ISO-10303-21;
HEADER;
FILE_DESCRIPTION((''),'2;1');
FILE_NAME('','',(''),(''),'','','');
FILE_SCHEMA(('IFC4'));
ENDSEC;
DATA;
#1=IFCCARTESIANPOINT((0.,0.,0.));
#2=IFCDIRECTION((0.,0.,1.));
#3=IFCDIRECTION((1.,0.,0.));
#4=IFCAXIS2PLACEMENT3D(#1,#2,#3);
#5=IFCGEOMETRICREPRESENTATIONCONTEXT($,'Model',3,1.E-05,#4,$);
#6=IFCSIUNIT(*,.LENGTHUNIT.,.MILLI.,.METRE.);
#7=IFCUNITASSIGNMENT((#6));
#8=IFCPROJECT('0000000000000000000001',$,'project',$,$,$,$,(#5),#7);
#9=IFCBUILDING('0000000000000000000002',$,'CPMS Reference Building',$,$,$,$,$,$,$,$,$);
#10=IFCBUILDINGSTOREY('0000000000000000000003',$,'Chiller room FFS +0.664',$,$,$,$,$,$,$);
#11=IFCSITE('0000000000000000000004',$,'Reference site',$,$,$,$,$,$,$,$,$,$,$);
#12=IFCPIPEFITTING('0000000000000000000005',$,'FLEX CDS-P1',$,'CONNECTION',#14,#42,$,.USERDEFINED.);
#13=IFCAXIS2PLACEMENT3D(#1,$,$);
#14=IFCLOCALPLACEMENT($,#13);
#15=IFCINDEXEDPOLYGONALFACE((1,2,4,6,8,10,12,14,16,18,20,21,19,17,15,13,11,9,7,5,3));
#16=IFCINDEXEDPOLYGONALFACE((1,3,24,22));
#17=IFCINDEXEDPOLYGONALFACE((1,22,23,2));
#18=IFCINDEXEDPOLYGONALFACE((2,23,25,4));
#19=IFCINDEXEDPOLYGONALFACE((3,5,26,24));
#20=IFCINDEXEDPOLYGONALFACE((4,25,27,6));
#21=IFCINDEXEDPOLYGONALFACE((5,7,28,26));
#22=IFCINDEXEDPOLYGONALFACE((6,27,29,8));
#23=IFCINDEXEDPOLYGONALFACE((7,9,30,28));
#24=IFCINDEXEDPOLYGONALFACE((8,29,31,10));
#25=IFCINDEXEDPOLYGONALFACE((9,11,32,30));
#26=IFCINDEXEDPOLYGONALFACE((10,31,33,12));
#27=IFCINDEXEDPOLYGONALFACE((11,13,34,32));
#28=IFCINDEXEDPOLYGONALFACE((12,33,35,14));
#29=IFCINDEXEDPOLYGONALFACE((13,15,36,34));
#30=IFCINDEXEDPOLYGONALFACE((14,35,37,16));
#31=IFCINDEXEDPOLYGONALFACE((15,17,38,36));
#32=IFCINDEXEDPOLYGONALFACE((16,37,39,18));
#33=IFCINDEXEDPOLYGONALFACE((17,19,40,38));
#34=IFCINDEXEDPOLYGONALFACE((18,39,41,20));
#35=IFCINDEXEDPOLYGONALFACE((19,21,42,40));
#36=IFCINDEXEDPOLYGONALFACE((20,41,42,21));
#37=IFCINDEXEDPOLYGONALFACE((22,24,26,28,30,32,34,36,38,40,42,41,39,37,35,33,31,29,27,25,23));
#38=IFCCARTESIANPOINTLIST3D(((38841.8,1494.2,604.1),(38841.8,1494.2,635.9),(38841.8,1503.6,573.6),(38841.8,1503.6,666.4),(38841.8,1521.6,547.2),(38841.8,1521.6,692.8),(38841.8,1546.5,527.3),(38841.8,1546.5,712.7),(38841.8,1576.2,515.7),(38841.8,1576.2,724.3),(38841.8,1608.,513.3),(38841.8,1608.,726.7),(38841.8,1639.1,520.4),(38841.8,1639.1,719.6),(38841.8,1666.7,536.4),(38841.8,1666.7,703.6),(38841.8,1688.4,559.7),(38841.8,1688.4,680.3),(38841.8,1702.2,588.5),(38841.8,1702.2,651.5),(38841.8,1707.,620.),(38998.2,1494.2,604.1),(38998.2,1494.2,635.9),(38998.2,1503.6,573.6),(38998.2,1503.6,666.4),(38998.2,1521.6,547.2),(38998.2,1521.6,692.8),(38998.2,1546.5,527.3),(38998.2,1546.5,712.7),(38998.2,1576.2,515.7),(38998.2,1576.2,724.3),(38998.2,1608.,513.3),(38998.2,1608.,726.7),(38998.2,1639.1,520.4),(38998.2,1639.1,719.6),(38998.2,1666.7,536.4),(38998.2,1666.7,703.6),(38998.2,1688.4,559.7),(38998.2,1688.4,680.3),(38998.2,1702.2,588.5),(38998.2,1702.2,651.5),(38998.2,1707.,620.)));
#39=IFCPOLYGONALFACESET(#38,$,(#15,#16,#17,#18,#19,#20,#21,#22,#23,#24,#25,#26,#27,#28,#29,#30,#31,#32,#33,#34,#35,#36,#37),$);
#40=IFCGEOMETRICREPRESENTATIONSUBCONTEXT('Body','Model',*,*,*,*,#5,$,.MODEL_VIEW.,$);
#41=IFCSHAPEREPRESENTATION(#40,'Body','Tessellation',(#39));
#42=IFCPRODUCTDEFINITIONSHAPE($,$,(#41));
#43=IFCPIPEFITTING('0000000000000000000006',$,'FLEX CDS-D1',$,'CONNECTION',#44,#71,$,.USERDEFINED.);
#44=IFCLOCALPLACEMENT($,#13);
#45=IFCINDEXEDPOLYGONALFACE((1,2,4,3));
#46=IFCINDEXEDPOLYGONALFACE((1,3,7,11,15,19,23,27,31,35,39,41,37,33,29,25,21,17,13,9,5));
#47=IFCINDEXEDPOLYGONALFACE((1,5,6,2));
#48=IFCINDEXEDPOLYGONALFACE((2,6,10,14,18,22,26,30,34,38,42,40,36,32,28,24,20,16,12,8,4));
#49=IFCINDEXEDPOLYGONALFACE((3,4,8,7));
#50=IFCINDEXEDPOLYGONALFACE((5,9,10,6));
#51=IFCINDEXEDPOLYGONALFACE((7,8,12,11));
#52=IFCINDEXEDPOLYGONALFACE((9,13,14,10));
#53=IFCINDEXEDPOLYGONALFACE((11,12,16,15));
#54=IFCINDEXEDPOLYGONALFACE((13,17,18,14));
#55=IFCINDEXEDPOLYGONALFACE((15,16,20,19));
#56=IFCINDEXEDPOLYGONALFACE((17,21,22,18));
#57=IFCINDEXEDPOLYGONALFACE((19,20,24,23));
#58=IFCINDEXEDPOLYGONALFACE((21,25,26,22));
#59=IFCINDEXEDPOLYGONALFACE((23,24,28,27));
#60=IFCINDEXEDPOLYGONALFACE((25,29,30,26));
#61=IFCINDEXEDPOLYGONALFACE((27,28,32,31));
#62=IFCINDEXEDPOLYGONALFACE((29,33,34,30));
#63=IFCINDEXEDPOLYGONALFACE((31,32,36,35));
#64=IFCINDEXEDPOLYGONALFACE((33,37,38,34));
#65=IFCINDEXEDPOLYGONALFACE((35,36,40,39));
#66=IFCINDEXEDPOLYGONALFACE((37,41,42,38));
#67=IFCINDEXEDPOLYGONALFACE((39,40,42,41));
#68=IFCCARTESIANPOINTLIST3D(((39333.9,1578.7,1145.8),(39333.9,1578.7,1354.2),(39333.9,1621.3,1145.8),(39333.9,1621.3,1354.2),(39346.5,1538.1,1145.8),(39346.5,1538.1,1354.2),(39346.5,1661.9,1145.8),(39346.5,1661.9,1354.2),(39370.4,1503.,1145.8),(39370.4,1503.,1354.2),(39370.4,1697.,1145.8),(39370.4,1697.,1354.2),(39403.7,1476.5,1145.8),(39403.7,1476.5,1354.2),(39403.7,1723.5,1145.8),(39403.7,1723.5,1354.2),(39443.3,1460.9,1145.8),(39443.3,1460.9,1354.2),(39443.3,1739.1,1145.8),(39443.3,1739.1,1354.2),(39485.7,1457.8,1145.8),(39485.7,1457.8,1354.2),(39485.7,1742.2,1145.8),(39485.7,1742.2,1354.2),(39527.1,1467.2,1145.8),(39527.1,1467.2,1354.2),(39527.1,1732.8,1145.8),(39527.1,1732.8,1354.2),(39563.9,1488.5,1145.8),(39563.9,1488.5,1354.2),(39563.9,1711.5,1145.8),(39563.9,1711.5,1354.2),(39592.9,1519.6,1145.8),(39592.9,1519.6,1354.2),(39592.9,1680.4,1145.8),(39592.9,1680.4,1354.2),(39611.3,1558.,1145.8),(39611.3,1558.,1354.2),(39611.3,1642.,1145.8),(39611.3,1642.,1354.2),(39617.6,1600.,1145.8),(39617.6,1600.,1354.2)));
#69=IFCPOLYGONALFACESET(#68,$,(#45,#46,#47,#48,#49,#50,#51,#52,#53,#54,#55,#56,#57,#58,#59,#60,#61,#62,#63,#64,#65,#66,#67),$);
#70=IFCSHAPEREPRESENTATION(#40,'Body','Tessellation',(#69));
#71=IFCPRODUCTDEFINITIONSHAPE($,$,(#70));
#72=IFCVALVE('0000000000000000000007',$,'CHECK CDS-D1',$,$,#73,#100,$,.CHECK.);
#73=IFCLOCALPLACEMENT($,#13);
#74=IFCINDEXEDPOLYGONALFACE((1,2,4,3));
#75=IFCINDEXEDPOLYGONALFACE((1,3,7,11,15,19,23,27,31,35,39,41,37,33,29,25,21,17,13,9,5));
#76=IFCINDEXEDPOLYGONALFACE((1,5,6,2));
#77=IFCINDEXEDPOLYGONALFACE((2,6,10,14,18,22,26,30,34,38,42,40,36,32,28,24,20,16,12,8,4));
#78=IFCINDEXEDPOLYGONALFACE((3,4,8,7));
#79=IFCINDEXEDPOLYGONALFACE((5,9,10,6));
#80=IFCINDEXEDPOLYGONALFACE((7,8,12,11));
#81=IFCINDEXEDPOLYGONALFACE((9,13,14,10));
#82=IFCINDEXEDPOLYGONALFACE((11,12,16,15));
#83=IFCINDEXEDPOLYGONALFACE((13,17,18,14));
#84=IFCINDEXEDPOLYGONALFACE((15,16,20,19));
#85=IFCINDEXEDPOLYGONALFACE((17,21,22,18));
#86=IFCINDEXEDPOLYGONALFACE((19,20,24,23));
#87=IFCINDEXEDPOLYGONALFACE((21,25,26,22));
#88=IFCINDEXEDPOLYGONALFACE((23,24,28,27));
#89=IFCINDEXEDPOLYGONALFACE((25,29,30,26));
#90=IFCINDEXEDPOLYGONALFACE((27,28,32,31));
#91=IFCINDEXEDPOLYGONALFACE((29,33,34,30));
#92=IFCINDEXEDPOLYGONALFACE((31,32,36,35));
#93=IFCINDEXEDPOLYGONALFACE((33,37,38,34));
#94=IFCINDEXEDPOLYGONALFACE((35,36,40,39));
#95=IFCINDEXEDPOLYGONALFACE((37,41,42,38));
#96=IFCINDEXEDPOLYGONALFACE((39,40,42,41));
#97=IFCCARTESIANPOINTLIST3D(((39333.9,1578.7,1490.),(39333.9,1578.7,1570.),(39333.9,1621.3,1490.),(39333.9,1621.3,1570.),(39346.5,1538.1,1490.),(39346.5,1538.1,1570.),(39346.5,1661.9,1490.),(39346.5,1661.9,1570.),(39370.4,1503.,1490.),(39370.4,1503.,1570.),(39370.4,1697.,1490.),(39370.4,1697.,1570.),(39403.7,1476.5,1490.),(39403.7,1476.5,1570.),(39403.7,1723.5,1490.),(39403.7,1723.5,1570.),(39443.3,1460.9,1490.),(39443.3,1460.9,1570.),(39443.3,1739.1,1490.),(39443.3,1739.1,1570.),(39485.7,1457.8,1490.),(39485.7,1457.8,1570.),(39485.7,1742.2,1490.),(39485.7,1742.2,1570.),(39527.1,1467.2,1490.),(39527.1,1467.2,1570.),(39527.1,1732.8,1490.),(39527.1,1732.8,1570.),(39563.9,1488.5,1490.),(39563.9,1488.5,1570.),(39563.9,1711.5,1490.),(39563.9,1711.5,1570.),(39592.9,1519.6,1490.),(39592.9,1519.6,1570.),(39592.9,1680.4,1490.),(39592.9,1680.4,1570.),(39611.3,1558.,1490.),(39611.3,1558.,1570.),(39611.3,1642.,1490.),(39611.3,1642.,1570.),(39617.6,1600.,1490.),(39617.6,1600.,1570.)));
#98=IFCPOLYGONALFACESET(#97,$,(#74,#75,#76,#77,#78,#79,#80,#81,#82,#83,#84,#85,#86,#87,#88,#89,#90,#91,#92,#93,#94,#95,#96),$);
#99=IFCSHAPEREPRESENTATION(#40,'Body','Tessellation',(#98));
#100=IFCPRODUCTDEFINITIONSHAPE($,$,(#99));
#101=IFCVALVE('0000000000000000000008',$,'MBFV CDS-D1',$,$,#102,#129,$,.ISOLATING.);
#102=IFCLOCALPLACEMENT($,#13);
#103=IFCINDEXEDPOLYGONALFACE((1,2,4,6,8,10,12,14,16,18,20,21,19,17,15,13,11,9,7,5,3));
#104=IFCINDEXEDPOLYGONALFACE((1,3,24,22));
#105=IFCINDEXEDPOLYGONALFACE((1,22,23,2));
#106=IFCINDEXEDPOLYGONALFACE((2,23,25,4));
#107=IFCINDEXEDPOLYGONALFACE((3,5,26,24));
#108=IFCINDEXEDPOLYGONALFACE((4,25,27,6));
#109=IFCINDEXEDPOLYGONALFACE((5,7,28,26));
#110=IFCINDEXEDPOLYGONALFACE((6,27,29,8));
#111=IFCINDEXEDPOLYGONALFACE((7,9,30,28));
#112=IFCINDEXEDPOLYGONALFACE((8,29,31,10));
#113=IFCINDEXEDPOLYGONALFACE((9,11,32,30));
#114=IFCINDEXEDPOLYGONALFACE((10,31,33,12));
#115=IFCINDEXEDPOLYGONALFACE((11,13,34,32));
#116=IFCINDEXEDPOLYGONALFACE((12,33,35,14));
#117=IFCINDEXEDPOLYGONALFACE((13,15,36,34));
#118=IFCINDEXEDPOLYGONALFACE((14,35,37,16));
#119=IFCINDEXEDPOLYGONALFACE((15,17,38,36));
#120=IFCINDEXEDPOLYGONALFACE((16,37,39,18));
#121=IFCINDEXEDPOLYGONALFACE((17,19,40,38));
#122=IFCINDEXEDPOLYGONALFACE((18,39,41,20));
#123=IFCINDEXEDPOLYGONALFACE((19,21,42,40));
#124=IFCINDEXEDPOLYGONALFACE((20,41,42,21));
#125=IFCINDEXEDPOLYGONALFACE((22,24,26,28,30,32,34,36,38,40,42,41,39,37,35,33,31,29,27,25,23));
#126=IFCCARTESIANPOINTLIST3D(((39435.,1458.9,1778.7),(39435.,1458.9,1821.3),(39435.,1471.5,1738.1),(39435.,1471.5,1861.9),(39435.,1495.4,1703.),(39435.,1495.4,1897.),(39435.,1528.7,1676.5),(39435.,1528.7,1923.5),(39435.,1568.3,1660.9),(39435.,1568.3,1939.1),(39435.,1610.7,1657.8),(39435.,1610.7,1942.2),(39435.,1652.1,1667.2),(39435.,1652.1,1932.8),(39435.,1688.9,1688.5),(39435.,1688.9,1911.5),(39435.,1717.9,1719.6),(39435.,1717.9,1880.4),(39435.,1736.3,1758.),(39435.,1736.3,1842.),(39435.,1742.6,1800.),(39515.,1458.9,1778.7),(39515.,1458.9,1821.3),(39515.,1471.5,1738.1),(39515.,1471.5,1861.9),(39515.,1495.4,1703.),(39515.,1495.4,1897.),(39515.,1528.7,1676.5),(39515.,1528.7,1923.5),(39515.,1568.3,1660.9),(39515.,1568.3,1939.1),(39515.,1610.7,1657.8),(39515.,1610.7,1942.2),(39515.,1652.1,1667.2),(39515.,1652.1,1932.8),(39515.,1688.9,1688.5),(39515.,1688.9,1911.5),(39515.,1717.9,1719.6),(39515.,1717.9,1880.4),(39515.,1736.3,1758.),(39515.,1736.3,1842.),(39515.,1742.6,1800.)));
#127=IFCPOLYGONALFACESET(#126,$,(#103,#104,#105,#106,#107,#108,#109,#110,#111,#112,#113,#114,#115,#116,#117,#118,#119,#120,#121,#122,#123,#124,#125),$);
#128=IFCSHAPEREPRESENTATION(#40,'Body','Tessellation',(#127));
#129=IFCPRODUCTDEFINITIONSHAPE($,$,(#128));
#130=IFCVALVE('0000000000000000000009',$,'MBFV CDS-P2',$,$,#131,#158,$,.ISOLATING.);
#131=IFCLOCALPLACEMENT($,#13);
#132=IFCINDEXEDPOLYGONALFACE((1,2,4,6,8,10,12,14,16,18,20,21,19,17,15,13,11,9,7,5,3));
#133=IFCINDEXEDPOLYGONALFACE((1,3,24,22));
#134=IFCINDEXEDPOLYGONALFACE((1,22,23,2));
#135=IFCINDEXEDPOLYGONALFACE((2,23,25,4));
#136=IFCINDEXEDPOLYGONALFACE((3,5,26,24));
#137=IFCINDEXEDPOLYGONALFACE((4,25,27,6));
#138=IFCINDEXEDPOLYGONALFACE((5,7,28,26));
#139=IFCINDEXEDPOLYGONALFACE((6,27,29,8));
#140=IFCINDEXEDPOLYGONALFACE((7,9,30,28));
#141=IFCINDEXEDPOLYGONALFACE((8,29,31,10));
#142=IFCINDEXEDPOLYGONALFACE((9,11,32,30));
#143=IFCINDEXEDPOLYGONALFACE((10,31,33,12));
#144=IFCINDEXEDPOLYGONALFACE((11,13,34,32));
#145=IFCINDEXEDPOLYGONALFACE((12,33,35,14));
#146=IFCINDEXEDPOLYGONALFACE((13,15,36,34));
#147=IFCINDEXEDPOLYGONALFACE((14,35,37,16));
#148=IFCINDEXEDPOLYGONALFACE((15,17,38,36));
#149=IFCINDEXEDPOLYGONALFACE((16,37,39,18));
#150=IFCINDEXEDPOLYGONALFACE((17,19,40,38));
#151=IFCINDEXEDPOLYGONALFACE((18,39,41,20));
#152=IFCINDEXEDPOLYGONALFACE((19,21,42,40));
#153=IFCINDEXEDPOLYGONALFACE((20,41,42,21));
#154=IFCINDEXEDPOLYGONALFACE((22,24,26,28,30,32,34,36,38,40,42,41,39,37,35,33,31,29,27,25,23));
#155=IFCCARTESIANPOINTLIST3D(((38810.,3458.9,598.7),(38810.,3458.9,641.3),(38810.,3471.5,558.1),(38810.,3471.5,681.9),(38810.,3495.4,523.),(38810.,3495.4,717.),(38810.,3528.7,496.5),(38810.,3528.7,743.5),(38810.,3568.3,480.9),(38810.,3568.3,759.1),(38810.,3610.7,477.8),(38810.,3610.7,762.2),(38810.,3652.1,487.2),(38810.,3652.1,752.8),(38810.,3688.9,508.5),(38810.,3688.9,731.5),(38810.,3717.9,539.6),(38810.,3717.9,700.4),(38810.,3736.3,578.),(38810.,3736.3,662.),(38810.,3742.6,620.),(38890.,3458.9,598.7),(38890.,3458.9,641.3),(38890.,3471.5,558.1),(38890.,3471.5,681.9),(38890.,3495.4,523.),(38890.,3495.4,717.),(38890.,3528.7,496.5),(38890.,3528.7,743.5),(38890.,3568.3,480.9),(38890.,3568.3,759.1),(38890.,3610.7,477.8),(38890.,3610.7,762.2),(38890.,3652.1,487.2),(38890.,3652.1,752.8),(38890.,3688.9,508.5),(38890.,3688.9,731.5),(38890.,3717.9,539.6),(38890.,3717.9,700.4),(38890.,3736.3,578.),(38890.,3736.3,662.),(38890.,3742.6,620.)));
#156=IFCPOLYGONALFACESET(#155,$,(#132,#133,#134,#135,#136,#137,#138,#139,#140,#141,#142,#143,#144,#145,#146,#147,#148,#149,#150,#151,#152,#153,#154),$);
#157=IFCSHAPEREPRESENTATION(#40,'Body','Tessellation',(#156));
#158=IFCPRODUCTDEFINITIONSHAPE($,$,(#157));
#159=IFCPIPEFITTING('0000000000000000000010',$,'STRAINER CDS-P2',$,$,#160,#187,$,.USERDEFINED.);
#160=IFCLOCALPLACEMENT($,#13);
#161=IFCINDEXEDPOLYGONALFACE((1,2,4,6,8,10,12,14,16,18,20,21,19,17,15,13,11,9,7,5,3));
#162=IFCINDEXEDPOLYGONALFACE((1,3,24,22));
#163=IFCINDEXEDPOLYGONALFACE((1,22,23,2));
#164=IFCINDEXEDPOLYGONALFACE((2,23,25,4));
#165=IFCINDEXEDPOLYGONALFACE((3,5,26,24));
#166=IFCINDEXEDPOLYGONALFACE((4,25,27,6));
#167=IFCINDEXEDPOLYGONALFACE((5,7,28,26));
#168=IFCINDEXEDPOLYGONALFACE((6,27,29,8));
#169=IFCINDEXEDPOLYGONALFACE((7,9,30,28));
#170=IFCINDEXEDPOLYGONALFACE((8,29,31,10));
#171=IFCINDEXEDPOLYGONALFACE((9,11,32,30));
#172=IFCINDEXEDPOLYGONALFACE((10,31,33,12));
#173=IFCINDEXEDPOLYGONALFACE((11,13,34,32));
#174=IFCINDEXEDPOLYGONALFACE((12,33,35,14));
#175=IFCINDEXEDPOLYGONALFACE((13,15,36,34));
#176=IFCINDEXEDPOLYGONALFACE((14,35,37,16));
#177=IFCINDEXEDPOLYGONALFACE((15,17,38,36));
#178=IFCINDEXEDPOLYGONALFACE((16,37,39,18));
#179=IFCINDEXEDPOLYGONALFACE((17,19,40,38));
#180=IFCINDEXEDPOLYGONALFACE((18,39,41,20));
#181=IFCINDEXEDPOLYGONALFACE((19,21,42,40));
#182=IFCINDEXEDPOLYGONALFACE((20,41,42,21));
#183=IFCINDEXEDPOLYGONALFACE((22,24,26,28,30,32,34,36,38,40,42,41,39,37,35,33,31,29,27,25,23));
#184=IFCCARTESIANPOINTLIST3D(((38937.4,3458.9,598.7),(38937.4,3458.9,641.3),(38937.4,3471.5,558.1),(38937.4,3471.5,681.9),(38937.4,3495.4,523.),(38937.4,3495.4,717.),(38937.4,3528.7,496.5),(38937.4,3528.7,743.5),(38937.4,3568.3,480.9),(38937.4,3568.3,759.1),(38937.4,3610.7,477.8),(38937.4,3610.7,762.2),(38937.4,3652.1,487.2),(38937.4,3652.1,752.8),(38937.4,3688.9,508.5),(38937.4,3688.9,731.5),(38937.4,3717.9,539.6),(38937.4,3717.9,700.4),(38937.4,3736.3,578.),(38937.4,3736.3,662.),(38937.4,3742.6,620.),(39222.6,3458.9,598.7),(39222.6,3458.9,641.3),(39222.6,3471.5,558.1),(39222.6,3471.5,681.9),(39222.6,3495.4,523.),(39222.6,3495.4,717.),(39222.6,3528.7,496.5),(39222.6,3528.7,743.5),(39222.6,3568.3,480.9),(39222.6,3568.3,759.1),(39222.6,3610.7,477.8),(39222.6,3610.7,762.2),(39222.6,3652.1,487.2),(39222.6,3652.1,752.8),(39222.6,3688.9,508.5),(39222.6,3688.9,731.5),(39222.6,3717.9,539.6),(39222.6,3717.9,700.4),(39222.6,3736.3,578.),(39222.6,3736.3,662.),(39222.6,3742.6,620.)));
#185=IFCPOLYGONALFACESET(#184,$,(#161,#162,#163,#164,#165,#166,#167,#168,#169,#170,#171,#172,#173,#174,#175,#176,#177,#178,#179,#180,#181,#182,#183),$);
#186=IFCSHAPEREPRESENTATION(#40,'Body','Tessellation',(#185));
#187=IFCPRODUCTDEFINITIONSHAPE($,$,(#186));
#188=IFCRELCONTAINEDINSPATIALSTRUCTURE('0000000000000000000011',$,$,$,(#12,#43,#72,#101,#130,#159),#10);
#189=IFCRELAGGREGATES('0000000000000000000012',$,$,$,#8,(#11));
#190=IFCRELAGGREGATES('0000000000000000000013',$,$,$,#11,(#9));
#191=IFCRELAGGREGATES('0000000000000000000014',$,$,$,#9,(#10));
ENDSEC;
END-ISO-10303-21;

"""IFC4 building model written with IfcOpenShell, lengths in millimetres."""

from ifc_helpers import new_model, si_unit, frame, origin_with_axes, origin_2d, place, context, subcontext, project, spatial, circle_curve, outline, extrude, element, save


model = new_model("IFC4")

# Units and contexts
model_context = context("Model", 3, precision=1e-05, world=origin_with_axes())
body_context = subcontext(model_context, "Body", "Model", "MODEL_VIEW")
ifc_project = project(units=[si_unit("LENGTHUNIT", "METRE", prefix="MILLI")], contexts=[model_context])

# Site, building, storey
site = spatial("IfcSite", under=ifc_project, Name="Reference site")
building = spatial("IfcBuilding", under=site, Name="CPMS Reference Building")
storey = spatial("IfcBuildingStorey", under=building, Name="Chiller room FFS +0.664")

# Pipe fittings
pipe_fitting_1_placement = place(None, origin_with_axes())
element("IfcPipeFitting", 1, at=pipe_fitting_1_placement, inside=storey, Name="FLEX CDS-P1", ObjectType="CONNECTION", PredefinedType="USERDEFINED", context=body_context, shape_type="SweptSolid", body=[
    extrude(outline(circle_curve(origin_2d(), 107.0)), frame((38841.8, 1600.0, 620.0), z_axis=(1.0, 0.0, 0.0), x_axis=(0.0, 1.0, 0.0)), (0.0, 0.0, 1.0), 156.4),
])
pipe_fitting_2_placement = place(None, origin_with_axes())
element("IfcPipeFitting", 2, at=pipe_fitting_2_placement, inside=storey, Name="FLEX CDS-D1", ObjectType="CONNECTION", PredefinedType="USERDEFINED", context=body_context, shape_type="SweptSolid", body=[
    extrude(outline(circle_curve(origin_2d(), 142.6)), frame((39475.0, 1600.0, 1145.8), z_axis=(0.0, 0.0, 1.0), x_axis=(1.0, 0.0, 0.0)), (0.0, 0.0, 1.0), 208.5),
])

# Valves
valve_1_placement = place(None, origin_with_axes())
element("IfcValve", 3, at=valve_1_placement, inside=storey, Name="CHECK CDS-D1", PredefinedType="CHECK", context=body_context, shape_type="SweptSolid", body=[
    extrude(outline(circle_curve(origin_2d(), 142.6)), frame((39475.0, 1600.0, 1490.0), z_axis=(0.0, 0.0, 1.0), x_axis=(1.0, 0.0, 0.0)), (0.0, 0.0, 1.0), 80.0),
])
valve_2_placement = place(None, origin_with_axes())
element("IfcValve", 4, at=valve_2_placement, inside=storey, Name="MBFV CDS-D1", PredefinedType="ISOLATING", context=body_context, shape_type="SweptSolid", body=[
    extrude(outline(circle_curve(origin_2d(), 142.6)), frame((39435.0, 1600.0, 1800.0), z_axis=(1.0, 0.0, 0.0), x_axis=(0.0, 1.0, 0.0)), (0.0, 0.0, 1.0), 80.0),
])
valve_3_placement = place(None, origin_with_axes())
element("IfcValve", 5, at=valve_3_placement, inside=storey, Name="MBFV CDS-P2", PredefinedType="ISOLATING", context=body_context, shape_type="SweptSolid", body=[
    extrude(outline(circle_curve(origin_2d(), 142.6)), frame((38810.0, 3600.0, 620.0), z_axis=(1.0, 0.0, 0.0), x_axis=(0.0, 1.0, 0.0)), (0.0, 0.0, 1.0), 80.0),
])

# Pipe fitting
pipe_fitting_3_placement = place(None, origin_with_axes())
element("IfcPipeFitting", 6, at=pipe_fitting_3_placement, inside=storey, Name="STRAINER CDS-P2", PredefinedType="USERDEFINED", context=body_context, shape_type="SweptSolid", body=[
    extrude(outline(circle_curve(origin_2d(), 142.6)), frame((38937.4, 3600.0, 620.0), z_axis=(1.0, 0.0, 0.0), x_axis=(0.0, 1.0, 0.0)), (0.0, 0.0, 1.0), 285.3),
])

save(model, "model.ifc")
